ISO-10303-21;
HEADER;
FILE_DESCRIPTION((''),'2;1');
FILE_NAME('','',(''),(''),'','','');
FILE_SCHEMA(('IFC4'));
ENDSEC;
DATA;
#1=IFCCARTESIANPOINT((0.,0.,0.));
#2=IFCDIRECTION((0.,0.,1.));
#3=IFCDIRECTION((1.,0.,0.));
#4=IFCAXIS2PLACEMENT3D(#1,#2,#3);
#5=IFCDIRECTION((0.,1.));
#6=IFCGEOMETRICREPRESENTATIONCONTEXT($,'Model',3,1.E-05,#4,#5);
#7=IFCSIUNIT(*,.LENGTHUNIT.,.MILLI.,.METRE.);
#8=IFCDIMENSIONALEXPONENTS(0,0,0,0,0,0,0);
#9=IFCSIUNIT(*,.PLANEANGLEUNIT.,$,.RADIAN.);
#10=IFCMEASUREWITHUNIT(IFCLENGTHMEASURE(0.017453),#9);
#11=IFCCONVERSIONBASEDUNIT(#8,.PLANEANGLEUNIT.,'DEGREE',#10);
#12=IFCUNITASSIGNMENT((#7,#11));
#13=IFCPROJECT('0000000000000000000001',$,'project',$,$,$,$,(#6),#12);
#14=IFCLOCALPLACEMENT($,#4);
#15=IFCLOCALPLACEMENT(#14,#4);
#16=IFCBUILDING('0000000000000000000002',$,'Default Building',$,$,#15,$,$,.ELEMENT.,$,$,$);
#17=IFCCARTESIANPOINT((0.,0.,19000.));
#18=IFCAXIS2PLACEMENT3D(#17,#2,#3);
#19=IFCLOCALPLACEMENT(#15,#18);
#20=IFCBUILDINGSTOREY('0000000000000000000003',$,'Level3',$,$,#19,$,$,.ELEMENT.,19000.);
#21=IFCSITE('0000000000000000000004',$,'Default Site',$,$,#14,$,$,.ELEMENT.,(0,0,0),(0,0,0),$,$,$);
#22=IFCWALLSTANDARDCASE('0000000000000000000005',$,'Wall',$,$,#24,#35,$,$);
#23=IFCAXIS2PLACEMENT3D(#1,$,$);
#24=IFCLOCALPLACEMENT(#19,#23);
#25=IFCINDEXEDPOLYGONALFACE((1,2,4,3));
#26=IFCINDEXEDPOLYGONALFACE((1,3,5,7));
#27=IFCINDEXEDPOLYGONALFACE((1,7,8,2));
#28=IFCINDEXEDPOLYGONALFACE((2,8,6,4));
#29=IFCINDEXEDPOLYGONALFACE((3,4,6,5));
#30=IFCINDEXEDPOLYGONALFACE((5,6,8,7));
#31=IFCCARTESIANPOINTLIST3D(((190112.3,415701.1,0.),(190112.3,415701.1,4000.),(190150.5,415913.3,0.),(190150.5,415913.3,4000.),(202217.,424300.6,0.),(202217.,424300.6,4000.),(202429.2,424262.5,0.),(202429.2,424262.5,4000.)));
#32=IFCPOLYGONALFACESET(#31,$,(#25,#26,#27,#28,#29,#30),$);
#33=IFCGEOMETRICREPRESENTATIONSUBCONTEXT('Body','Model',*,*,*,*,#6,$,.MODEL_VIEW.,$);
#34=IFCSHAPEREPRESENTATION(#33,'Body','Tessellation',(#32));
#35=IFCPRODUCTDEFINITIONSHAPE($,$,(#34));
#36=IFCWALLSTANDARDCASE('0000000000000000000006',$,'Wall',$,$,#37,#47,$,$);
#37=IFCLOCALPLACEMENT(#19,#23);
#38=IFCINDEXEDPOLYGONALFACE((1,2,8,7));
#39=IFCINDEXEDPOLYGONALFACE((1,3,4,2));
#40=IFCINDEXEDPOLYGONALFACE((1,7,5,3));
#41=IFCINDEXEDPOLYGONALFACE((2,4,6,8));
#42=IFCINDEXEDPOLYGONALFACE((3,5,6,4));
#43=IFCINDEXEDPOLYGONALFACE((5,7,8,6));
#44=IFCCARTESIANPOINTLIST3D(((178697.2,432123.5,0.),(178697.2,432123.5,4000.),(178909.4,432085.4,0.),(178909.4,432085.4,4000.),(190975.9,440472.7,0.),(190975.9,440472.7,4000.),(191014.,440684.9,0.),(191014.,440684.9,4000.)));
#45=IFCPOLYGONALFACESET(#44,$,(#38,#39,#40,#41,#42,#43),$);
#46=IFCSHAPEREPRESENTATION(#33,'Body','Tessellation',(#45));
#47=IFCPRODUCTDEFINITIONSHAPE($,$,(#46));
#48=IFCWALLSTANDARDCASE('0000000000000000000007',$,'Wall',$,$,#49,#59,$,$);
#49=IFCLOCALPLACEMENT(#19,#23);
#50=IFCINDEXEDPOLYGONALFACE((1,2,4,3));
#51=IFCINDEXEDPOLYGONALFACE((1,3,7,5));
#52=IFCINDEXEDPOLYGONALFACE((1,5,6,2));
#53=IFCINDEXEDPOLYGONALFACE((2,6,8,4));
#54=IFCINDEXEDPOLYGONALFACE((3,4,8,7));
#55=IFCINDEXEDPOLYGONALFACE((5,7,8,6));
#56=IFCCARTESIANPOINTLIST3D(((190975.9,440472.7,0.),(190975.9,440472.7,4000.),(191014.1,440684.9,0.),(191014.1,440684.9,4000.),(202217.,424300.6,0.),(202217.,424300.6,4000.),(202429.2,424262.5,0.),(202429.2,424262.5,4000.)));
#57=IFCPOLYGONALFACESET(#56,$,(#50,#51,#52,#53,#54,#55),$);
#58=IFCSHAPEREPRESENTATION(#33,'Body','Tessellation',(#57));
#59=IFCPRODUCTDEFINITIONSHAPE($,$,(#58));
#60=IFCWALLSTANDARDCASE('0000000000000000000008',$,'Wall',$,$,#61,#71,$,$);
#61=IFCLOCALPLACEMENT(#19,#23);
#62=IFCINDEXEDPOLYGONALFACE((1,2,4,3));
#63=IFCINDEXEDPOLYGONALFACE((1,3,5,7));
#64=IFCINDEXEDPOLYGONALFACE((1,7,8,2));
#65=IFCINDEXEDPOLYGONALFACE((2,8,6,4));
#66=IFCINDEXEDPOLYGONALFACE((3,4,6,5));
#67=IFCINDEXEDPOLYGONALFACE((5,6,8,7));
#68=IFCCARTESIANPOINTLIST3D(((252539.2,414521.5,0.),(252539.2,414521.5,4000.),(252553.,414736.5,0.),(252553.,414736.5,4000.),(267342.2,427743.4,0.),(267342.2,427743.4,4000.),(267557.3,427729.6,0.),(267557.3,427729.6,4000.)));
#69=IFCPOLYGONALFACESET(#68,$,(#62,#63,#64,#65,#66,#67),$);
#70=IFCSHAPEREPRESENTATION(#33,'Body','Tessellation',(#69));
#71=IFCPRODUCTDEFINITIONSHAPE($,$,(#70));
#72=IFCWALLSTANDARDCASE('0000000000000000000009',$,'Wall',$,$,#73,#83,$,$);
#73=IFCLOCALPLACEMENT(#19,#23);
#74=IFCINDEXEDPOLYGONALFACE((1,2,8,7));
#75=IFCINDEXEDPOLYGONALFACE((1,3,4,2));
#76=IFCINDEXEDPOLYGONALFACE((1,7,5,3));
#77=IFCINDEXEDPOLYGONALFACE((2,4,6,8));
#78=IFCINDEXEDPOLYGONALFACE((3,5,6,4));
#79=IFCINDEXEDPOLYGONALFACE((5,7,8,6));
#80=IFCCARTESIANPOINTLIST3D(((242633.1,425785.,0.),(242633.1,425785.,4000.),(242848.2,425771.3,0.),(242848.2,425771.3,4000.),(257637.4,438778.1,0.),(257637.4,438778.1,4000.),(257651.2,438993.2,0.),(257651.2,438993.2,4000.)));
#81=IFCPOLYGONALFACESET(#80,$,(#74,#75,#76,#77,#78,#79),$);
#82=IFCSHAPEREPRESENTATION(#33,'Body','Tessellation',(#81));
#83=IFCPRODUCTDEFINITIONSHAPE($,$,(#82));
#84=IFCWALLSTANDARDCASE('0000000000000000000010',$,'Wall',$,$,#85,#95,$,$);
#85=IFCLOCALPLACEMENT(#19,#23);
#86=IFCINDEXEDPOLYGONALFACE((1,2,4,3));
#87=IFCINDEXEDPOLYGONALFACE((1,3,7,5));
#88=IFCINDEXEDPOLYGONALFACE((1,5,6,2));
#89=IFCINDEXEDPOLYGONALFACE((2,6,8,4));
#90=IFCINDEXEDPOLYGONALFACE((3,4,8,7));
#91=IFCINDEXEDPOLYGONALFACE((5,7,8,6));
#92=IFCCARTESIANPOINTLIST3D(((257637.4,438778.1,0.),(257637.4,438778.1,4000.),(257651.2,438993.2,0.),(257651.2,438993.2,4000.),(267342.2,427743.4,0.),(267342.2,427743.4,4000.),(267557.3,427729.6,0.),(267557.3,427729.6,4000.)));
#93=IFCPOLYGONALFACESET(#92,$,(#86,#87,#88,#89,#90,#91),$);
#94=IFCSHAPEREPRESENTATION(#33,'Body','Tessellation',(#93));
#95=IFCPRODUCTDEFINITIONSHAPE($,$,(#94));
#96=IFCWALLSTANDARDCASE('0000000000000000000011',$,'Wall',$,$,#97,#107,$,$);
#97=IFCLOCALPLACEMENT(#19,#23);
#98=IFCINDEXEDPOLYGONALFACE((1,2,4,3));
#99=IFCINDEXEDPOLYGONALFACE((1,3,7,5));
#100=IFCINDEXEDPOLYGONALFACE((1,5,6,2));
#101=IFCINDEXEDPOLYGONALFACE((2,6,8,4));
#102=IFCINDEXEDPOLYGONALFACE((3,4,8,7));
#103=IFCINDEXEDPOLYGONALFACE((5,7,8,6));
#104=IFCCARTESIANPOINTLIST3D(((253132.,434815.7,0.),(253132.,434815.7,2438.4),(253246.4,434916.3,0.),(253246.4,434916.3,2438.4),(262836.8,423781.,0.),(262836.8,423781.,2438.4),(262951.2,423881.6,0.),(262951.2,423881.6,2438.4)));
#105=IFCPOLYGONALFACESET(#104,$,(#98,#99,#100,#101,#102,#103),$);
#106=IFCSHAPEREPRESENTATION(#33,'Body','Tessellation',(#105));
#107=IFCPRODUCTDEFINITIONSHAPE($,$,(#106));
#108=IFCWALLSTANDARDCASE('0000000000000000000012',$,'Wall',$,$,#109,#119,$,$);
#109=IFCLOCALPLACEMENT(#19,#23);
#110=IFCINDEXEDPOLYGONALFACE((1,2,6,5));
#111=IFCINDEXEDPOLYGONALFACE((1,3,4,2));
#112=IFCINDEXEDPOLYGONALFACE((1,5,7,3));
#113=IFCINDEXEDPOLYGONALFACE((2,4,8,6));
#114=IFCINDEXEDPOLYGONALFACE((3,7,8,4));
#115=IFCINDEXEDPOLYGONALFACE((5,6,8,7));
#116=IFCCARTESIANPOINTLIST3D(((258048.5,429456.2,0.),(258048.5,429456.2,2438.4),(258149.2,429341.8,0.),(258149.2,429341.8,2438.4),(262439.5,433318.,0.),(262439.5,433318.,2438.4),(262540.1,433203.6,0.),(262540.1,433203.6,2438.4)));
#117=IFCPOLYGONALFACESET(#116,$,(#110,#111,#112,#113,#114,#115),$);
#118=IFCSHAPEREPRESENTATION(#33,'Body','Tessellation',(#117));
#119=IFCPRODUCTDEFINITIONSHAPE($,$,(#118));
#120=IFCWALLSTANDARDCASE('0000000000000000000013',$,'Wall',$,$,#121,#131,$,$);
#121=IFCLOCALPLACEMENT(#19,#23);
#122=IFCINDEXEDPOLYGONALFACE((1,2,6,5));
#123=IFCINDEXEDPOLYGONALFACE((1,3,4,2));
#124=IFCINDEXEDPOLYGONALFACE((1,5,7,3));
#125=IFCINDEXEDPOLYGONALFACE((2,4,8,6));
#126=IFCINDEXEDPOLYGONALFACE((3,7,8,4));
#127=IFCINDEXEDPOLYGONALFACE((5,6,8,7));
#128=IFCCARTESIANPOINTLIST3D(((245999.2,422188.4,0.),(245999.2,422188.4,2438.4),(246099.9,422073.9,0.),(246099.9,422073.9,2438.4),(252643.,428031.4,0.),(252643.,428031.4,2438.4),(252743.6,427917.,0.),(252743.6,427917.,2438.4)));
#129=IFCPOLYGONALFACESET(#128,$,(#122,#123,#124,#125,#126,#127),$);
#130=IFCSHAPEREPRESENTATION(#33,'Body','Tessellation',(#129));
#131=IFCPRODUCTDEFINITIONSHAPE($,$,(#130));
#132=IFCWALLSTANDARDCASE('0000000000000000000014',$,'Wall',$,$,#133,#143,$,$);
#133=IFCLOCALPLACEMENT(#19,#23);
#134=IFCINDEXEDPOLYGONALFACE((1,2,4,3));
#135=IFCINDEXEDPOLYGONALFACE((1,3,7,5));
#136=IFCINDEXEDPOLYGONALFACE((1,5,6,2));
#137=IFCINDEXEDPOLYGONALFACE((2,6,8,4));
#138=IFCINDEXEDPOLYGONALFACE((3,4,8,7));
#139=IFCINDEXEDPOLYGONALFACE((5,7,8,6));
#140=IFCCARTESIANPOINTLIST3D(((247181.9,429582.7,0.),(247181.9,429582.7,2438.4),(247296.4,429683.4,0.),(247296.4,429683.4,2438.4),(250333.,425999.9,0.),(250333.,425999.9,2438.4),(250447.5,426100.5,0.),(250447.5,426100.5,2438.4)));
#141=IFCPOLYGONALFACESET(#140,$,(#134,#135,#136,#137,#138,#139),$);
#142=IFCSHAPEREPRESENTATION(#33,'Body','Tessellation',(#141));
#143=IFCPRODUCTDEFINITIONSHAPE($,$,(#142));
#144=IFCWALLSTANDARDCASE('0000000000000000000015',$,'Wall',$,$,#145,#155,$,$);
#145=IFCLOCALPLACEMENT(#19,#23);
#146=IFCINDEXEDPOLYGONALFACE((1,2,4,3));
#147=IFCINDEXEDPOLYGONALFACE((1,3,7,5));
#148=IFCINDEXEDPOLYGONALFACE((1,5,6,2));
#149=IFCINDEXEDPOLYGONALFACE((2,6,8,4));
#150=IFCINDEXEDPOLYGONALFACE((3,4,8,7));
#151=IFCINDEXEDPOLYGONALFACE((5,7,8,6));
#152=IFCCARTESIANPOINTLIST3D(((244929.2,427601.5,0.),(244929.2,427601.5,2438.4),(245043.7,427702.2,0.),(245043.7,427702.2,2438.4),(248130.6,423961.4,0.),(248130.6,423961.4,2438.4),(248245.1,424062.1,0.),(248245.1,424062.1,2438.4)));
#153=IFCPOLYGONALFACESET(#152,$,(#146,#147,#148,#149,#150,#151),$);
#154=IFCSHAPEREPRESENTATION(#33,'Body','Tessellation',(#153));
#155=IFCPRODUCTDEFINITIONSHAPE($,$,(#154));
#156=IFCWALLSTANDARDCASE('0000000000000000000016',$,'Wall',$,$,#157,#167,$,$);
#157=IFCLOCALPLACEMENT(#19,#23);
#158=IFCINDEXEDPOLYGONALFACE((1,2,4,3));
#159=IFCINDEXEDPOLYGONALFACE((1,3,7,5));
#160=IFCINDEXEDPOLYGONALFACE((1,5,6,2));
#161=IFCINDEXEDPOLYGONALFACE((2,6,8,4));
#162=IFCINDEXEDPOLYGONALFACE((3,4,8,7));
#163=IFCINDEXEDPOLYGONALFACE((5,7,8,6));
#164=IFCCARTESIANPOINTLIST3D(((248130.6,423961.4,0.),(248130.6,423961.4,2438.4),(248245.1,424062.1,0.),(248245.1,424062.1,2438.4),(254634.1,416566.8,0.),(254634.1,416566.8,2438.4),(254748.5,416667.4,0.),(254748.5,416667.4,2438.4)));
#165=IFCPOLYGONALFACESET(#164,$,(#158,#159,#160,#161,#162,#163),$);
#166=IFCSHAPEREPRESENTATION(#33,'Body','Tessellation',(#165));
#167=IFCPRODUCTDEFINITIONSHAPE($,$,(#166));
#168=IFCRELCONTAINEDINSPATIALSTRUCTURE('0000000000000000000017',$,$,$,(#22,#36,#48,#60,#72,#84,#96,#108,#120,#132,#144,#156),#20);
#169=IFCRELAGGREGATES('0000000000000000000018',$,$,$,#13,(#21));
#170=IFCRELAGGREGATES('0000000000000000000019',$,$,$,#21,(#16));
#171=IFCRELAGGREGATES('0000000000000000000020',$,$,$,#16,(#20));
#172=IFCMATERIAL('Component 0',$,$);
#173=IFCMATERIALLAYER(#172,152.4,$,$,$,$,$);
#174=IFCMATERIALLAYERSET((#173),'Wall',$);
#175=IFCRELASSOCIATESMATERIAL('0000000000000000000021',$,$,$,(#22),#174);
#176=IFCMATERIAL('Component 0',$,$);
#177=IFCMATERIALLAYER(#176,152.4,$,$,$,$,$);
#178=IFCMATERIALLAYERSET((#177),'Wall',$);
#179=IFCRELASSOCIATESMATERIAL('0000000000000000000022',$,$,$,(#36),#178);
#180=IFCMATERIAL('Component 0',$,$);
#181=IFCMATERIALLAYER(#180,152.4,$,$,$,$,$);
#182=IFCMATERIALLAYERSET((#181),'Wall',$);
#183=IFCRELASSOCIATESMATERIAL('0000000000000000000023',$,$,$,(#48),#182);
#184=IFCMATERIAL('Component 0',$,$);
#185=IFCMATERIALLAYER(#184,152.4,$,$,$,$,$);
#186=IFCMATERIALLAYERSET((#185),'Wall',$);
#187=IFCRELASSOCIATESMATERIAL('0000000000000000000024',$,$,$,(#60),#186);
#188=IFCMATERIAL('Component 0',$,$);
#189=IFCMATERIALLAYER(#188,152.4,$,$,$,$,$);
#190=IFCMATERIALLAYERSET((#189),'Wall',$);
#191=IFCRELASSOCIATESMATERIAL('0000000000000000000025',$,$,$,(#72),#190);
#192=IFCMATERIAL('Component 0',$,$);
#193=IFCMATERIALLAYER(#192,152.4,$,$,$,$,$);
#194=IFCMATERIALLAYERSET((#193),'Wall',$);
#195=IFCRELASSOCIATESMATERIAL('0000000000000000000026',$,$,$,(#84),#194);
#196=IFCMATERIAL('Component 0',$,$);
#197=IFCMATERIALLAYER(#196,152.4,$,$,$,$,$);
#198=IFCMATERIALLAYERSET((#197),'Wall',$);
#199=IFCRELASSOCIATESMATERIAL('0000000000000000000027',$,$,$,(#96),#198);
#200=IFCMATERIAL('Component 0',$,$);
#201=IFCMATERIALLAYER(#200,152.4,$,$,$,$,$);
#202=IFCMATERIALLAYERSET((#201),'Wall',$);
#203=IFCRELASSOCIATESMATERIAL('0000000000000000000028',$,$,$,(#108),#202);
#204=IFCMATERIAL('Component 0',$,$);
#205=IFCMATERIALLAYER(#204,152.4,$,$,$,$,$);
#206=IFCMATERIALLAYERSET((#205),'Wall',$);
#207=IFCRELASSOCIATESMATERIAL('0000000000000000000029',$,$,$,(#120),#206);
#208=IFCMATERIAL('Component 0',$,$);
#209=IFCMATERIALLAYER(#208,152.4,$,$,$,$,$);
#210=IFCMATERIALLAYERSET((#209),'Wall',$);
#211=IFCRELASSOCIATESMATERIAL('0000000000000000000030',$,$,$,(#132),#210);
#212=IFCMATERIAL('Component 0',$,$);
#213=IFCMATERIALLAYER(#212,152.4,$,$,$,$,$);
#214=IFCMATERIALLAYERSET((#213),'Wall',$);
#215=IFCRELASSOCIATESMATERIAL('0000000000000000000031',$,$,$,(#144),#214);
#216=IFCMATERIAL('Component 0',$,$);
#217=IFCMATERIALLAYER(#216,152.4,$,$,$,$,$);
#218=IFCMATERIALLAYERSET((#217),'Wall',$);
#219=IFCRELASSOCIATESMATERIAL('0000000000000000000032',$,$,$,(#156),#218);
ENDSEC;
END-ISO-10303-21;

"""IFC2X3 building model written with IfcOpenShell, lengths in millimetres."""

from ifc_helpers import new_model, entity, si_unit, converted_unit, direction, frame, origin_with_axes, place, context, subcontext, project, spatial, polyline, outline, extrude, material, layer, layer_set, layer_usage, element, save


model = new_model("IFC2X3")

# Units and contexts
model_context = context("Model", 3, precision=1e-05, world=origin_with_axes(), true_north=direction((0.0, 1.0)))
body_context = subcontext(model_context, "Body", "Model", "MODEL_VIEW")
ifc_project = project(units=[si_unit("LENGTHUNIT", "METRE", prefix="MILLI"), converted_unit("PLANEANGLEUNIT", "DEGREE", entity("IfcLengthMeasure", 0.017453), si_unit("PLANEANGLEUNIT", "RADIAN"), dimensions=[0, 0, 0, 0, 0, 0, 0])], contexts=[model_context])

# Site, building, storey
site_placement = place(None, origin_with_axes())
site = spatial("IfcSite", under=ifc_project, at=site_placement, Name="Default Site", CompositionType="ELEMENT", RefLatitude=(0, 0, 0), RefLongitude=(0, 0, 0))
building_placement = place(site_placement, origin_with_axes())
building = spatial("IfcBuilding", under=site, at=building_placement, Name="Default Building", CompositionType="ELEMENT")
storey_placement = place(building_placement, frame((0.0, 0.0, 19000.0), z_axis=(0.0, 0.0, 1.0), x_axis=(1.0, 0.0, 0.0)))
storey = spatial("IfcBuildingStorey", under=building, at=storey_placement, Name="Level3", CompositionType="ELEMENT", Elevation=19000.0)

# Walls
ifc_material_1 = material(Name="Component 0")
ifc_layer_1 = layer(ifc_material_1, 152.4)
ifc_layer_set_1 = layer_set([ifc_layer_1], Name="Wall")
ifc_layer_usage_1 = layer_usage(ifc_layer_set_1, "AXIS2", "POSITIVE", -76.2)
wall_1_placement = place(storey_placement, frame((202323.1, 424281.5, 0.0), z_axis=(0.0, 0.0, 1.0), x_axis=(-0.82112, -0.570755, 0.0)))
element("IfcWallStandardCase", 1, at=wall_1_placement, inside=storey, material=ifc_layer_usage_1, Name="Wall", context=body_context, shape_type="SweptSolid", body=[
    extrude(outline(polyline([(76.2, -76.2), (-76.2, 76.2), (14923.8, 76.2), (14771.4, -76.2), (76.2, -76.2)])), origin_with_axes(), (0.0, 0.0, 1.0), 4000.0),
])
ifc_material_2 = material(Name="Component 0")
ifc_layer_2 = layer(ifc_material_2, 152.4)
ifc_layer_set_2 = layer_set([ifc_layer_2], Name="Wall")
ifc_layer_usage_2 = layer_usage(ifc_layer_set_2, "AXIS2", "POSITIVE", -76.2)
wall_2_placement = place(storey_placement, frame((178803.3, 432104.5, 0.0), z_axis=(0.0, 0.0, 1.0), x_axis=(0.82112, 0.570755, 0.0)))
element("IfcWallStandardCase", 2, at=wall_2_placement, inside=storey, material=ifc_layer_usage_2, Name="Wall", context=body_context, shape_type="SweptSolid", body=[
    extrude(outline(polyline([(76.2, -76.2), (-76.2, 76.2), (14923.8, 76.2), (14771.4, -76.2), (76.2, -76.2)])), origin_with_axes(), (0.0, 0.0, 1.0), 4000.0),
])
ifc_material_3 = material(Name="Component 0")
ifc_layer_3 = layer(ifc_material_3, 152.4)
ifc_layer_set_3 = layer_set([ifc_layer_3], Name="Wall")
ifc_layer_usage_3 = layer_usage(ifc_layer_set_3, "AXIS2", "POSITIVE", -76.2)
wall_3_placement = place(storey_placement, frame((190995.0, 440578.8, 0.0), z_axis=(0.0, 0.0, 1.0), x_axis=(0.570755, -0.82112, 0.0)))
element("IfcWallStandardCase", 3, at=wall_3_placement, inside=storey, material=ifc_layer_usage_3, Name="Wall", context=body_context, shape_type="SweptSolid", body=[
    extrude(outline(polyline([(76.2, -76.2), (-76.2, 76.2), (19923.8, 76.2), (19771.4, -76.2), (76.2, -76.2)])), origin_with_axes(), (0.0, 0.0, 1.0), 4000.0),
])
ifc_material_4 = material(Name="Component 0")
ifc_layer_4 = layer(ifc_material_4, 152.4)
ifc_layer_set_4 = layer_set([ifc_layer_4], Name="Wall")
ifc_layer_usage_4 = layer_usage(ifc_layer_set_4, "AXIS2", "POSITIVE", -76.2)
wall_4_placement = place(storey_placement, frame((267449.8, 427736.5, 0.0), z_axis=(0.0, 0.0, 1.0), x_axis=(-0.750906, -0.660409, 0.0)))
element("IfcWallStandardCase", 4, at=wall_4_placement, inside=storey, material=ifc_layer_usage_4, Name="Wall", context=body_context, shape_type="SweptSolid", body=[
    extrude(outline(polyline([(76.2, -76.2), (-76.2, 76.2), (19923.8, 76.2), (19771.4, -76.2), (76.2, -76.2)])), origin_with_axes(), (0.0, 0.0, 1.0), 4000.0),
])
ifc_material_5 = material(Name="Component 0")
ifc_layer_5 = layer(ifc_material_5, 152.4)
ifc_layer_set_5 = layer_set([ifc_layer_5], Name="Wall")
ifc_layer_usage_5 = layer_usage(ifc_layer_set_5, "AXIS2", "POSITIVE", -76.2)
wall_5_placement = place(storey_placement, frame((242740.6, 425778.2, 0.0), z_axis=(0.0, 0.0, 1.0), x_axis=(0.750906, 0.660409, 0.0)))
element("IfcWallStandardCase", 5, at=wall_5_placement, inside=storey, material=ifc_layer_usage_5, Name="Wall", context=body_context, shape_type="SweptSolid", body=[
    extrude(outline(polyline([(76.2, -76.2), (-76.2, 76.2), (19923.8, 76.2), (19771.4, -76.2), (76.2, -76.2)])), origin_with_axes(), (0.0, 0.0, 1.0), 4000.0),
])
ifc_material_6 = material(Name="Component 0")
ifc_layer_6 = layer(ifc_material_6, 152.4)
ifc_layer_set_6 = layer_set([ifc_layer_6], Name="Wall")
ifc_layer_usage_6 = layer_usage(ifc_layer_set_6, "AXIS2", "POSITIVE", -76.2)
wall_6_placement = place(storey_placement, frame((257644.3, 438885.7, 0.0), z_axis=(0.0, 0.0, 1.0), x_axis=(0.660409, -0.750906, 0.0)))
element("IfcWallStandardCase", 6, at=wall_6_placement, inside=storey, material=ifc_layer_usage_6, Name="Wall", context=body_context, shape_type="SweptSolid", body=[
    extrude(outline(polyline([(76.2, -76.2), (-76.2, 76.2), (14923.8, 76.2), (14771.4, -76.2), (76.2, -76.2)])), origin_with_axes(), (0.0, 0.0, 1.0), 4000.0),
])
ifc_material_7 = material(Name="Component 0")
ifc_layer_7 = layer(ifc_material_7, 152.4)
ifc_layer_set_7 = layer_set([ifc_layer_7], Name="Wall")
ifc_layer_usage_7 = layer_usage(ifc_layer_set_7, "AXIS2", "POSITIVE", -76.2)
wall_7_placement = place(storey_placement, frame((253138.9, 434923.2, 0.0), z_axis=(0.0, 0.0, 1.0), x_axis=(0.660409, -0.750906, 0.0)))
element("IfcWallStandardCase", 7, at=wall_7_placement, inside=storey, material=ifc_layer_usage_7, Name="Wall", context=body_context, shape_type="SweptSolid", body=[
    extrude(outline(polyline([(76.2, -76.2), (76.2, 76.2), (14771.4, 76.2), (14771.4, -76.2), (76.2, -76.2)])), origin_with_axes(), (0.0, 0.0, 1.0), 2438.4),
])
ifc_material_8 = material(Name="Component 0")
ifc_layer_8 = layer(ifc_material_8, 152.4)
ifc_layer_set_8 = layer_set([ifc_layer_8], Name="Wall")
ifc_layer_usage_8 = layer_usage(ifc_layer_set_8, "AXIS2", "POSITIVE", -76.2)
wall_8_placement = place(storey_placement, frame((258041.6, 429348.7, 0.0), z_axis=(0.0, 0.0, 1.0), x_axis=(0.750906, 0.660409, 0.0)))
element("IfcWallStandardCase", 8, at=wall_8_placement, inside=storey, material=ifc_layer_usage_8, Name="Wall", context=body_context, shape_type="SweptSolid", body=[
    extrude(outline(polyline([(76.2, -76.2), (76.2, 76.2), (5923.8, 76.2), (5923.8, -76.2), (76.2, -76.2)])), origin_with_axes(), (0.0, 0.0, 1.0), 2438.4),
])
ifc_material_9 = material(Name="Component 0")
ifc_layer_9 = layer(ifc_material_9, 152.4)
ifc_layer_set_9 = layer_set([ifc_layer_9], Name="Wall")
ifc_layer_usage_9 = layer_usage(ifc_layer_set_9, "AXIS2", "POSITIVE", -76.2)
wall_9_placement = place(storey_placement, frame((245992.3, 422080.8, 0.0), z_axis=(0.0, 0.0, 1.0), x_axis=(0.750906, 0.660409, 0.0)))
element("IfcWallStandardCase", 9, at=wall_9_placement, inside=storey, material=ifc_layer_usage_9, Name="Wall", context=body_context, shape_type="SweptSolid", body=[
    extrude(outline(polyline([(76.2, -76.2), (76.2, 76.2), (8923.8, 76.2), (8923.8, -76.2), (76.2, -76.2)])), origin_with_axes(), (0.0, 0.0, 1.0), 2438.4),
])
ifc_material_10 = material(Name="Component 0")
ifc_layer_10 = layer(ifc_material_10, 152.4)
ifc_layer_set_10 = layer_set([ifc_layer_10], Name="Wall")
ifc_layer_usage_10 = layer_usage(ifc_layer_set_10, "AXIS2", "POSITIVE", -76.2)
wall_10_placement = place(storey_placement, frame((247188.8, 429690.3, 0.0), z_axis=(0.0, 0.0, 1.0), x_axis=(0.660409, -0.750906, 0.0)))
element("IfcWallStandardCase", 10, at=wall_10_placement, inside=storey, material=ifc_layer_usage_10, Name="Wall", context=body_context, shape_type="SweptSolid", body=[
    extrude(outline(polyline([(76.2, -76.2), (76.2, 76.2), (4847.6, 76.2), (4847.6, -76.2), (76.2, -76.2)])), origin_with_axes(), (0.0, 0.0, 1.0), 2438.4),
])
ifc_material_11 = material(Name="Component 0")
ifc_layer_11 = layer(ifc_material_11, 152.4)
ifc_layer_set_11 = layer_set([ifc_layer_11], Name="Wall")
ifc_layer_usage_11 = layer_usage(ifc_layer_set_11, "AXIS2", "POSITIVE", -76.2)
wall_11_placement = place(storey_placement, frame((244936.1, 427709.1, 0.0), z_axis=(0.0, 0.0, 1.0), x_axis=(0.660409, -0.750906, 0.0)))
element("IfcWallStandardCase", 11, at=wall_11_placement, inside=storey, material=ifc_layer_usage_11, Name="Wall", context=body_context, shape_type="SweptSolid", body=[
    extrude(outline(polyline([(76.2, -76.2), (76.2, 76.2), (4923.8, 76.2), (4923.8, -76.2), (76.2, -76.2)])), origin_with_axes(), (0.0, 0.0, 1.0), 2438.4),
])
ifc_material_12 = material(Name="Component 0")
ifc_layer_12 = layer(ifc_material_12, 152.4)
ifc_layer_set_12 = layer_set([ifc_layer_12], Name="Wall")
ifc_layer_usage_12 = layer_usage(ifc_layer_set_12, "AXIS2", "POSITIVE", -76.2)
wall_12_placement = place(storey_placement, frame((248187.8, 424011.7, 0.0), z_axis=(0.0, 0.0, 1.0), x_axis=(0.660409, -0.750906, 0.0)))
element("IfcWallStandardCase", 12, at=wall_12_placement, inside=storey, material=ifc_layer_usage_12, Name="Wall", context=body_context, shape_type="SweptSolid", body=[
    extrude(outline(polyline([(0.0, -76.2), (0.0, 76.2), (9847.6, 76.2), (9847.6, -76.2), (0.0, -76.2)])), origin_with_axes(), (0.0, 0.0, 1.0), 2438.4),
])

save(model, "model.ifc")
